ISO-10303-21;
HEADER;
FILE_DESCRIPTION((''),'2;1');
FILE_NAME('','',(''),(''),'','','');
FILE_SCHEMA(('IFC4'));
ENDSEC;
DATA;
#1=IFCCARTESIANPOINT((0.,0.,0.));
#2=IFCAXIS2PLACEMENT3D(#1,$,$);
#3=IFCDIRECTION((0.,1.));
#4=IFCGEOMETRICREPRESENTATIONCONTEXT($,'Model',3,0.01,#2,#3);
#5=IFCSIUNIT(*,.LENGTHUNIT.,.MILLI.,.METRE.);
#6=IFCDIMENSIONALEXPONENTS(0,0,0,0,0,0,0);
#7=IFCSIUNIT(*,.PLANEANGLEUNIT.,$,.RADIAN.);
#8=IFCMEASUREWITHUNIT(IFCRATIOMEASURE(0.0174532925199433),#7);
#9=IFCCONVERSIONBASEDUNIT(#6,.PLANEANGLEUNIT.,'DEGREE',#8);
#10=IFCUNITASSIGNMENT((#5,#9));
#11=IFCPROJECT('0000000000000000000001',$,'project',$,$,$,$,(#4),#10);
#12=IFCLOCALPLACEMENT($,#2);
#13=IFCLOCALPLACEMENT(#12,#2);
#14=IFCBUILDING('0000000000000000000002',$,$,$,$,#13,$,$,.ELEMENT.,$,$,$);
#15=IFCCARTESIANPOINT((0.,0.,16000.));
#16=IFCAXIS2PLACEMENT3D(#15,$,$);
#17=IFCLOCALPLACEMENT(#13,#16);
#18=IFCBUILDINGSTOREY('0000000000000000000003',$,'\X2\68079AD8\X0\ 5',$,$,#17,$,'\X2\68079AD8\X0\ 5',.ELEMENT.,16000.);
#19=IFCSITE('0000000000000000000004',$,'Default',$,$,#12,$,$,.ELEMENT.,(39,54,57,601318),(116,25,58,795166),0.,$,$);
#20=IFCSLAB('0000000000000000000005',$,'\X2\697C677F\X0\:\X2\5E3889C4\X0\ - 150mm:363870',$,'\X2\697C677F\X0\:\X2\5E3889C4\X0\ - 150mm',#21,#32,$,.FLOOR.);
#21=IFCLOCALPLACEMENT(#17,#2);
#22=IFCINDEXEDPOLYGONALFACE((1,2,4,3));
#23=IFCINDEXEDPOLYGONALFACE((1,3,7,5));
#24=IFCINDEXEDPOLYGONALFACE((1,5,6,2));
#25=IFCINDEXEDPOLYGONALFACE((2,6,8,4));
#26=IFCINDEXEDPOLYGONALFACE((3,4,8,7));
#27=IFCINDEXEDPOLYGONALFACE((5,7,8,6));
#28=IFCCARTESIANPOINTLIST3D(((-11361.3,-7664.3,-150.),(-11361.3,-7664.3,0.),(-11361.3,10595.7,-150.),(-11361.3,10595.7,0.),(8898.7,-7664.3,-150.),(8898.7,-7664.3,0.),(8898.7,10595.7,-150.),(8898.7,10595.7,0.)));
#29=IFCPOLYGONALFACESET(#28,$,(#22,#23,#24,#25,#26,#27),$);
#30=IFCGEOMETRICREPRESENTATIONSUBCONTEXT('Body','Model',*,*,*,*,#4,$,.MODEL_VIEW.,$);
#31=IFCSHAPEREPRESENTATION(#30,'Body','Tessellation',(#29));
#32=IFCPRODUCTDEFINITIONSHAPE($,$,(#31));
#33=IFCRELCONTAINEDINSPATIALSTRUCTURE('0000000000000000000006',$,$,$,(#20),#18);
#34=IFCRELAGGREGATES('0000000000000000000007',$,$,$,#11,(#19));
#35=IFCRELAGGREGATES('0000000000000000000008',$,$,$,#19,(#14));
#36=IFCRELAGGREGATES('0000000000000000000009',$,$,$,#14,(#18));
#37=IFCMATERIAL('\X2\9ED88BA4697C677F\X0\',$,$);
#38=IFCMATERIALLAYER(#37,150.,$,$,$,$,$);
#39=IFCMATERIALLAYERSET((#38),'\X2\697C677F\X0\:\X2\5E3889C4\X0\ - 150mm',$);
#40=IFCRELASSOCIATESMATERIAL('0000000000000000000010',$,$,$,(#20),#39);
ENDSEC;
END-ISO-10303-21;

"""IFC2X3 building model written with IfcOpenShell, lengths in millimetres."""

from ifc_helpers import new_model, entity, si_unit, converted_unit, direction, frame, frame_2d, origin, place, context, subcontext, project, spatial, rectangle, extrude, material, layer, layer_set, layer_usage, element, save


model = new_model("IFC2X3")

# Units and contexts
model_context = context("Model", 3, precision=0.01, world=origin(), true_north=direction((0.0, 1.0)))
body_context = subcontext(model_context, "Body", "Model", "MODEL_VIEW")
ifc_project = project(units=[si_unit("LENGTHUNIT", "METRE", prefix="MILLI"), converted_unit("PLANEANGLEUNIT", "DEGREE", entity("IfcRatioMeasure", 0.0174532925199433), si_unit("PLANEANGLEUNIT", "RADIAN"), dimensions=[0, 0, 0, 0, 0, 0, 0])], contexts=[model_context])

# Site, building, storey
site_placement = place(None, origin())
site = spatial("IfcSite", under=ifc_project, at=site_placement, Name="Default", CompositionType="ELEMENT", RefLatitude=(39, 54, 57, 601318), RefLongitude=(116, 25, 58, 795166), RefElevation=0.0)
building_placement = place(site_placement, origin())
building = spatial("IfcBuilding", under=site, at=building_placement, CompositionType="ELEMENT")
storey_placement = place(building_placement, frame((0.0, 0.0, 16000.0)))
storey = spatial("IfcBuildingStorey", under=building, at=storey_placement, Name="标高 5", LongName="标高 5", CompositionType="ELEMENT", Elevation=16000.0)

# Slab
ifc_material_1 = material(Name="默认楼板")
ifc_layer = layer(ifc_material_1, 150.0)
ifc_layer_set = layer_set([ifc_layer], Name="楼板:常规 - 150mm")
ifc_layer_usage = layer_usage(ifc_layer_set, "AXIS3", "POSITIVE", 0.0)
slab_placement = place(storey_placement, origin())
element("IfcSlab", 1, at=slab_placement, inside=storey, material=ifc_layer_usage, Name="楼板:常规 - 150mm:363870", ObjectType="楼板:常规 - 150mm", PredefinedType="FLOOR", context=body_context, shape_type="SweptSolid", body=[
    extrude(rectangle(XDim=18260.0, YDim=20260.0, at=frame_2d((0.0, 0.0), x_axis=(1.0, 0.0))), frame((-1231.3, 1465.7, 0.0), z_axis=(0.0, 0.0, -1.0), x_axis=(0.0, 1.0, 0.0)), (0.0, 0.0, 1.0), 150.0),
])

save(model, "model.ifc")
